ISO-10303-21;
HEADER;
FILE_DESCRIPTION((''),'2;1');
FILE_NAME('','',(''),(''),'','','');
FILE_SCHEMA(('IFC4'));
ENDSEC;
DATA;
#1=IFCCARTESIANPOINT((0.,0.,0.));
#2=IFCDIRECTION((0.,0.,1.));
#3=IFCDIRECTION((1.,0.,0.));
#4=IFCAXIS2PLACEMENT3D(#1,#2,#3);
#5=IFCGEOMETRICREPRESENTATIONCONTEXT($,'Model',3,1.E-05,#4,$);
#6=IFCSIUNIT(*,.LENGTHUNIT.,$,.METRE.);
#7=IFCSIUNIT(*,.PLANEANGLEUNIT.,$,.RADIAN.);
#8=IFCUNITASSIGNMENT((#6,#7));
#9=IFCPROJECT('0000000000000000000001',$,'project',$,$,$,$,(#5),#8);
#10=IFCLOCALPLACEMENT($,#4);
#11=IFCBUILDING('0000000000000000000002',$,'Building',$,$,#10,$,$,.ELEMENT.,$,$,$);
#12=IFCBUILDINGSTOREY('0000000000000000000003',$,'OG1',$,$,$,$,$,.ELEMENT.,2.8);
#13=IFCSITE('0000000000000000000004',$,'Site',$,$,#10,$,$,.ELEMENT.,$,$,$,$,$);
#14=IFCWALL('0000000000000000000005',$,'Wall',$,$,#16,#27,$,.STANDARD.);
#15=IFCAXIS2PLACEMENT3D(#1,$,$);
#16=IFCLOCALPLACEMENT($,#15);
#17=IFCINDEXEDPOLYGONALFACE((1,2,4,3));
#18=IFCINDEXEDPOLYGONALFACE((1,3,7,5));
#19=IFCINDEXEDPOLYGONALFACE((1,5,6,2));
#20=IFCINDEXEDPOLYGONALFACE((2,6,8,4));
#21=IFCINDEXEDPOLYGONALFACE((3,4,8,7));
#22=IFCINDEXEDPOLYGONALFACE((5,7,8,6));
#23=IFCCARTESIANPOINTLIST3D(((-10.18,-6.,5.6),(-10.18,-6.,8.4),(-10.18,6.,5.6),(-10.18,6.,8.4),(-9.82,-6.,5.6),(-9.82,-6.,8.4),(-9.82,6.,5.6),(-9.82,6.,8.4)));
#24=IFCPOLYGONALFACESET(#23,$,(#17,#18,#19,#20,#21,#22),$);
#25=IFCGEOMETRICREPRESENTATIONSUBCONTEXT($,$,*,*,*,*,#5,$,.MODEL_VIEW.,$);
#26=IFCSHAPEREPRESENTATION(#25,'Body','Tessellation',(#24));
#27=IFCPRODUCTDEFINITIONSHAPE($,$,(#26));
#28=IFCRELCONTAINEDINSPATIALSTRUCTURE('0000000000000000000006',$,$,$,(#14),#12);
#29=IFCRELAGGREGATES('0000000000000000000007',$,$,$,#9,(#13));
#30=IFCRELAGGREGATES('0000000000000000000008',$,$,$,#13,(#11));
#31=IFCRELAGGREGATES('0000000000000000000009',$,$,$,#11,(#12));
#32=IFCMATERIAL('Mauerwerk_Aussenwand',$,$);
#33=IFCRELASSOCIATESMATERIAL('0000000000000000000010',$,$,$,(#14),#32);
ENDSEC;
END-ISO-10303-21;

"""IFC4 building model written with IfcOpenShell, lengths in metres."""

from ifc_helpers import new_model, si_unit, frame, frame_2d, origin, origin_with_axes, place, context, subcontext, project, spatial, rectangle, extrude, material, element, save


model = new_model("IFC4")

# Units and contexts
model_context = context("Model", 3, precision=1e-05, world=origin_with_axes())
sub_context = subcontext(model_context, None, None, "MODEL_VIEW")
ifc_project = project(units=[si_unit("LENGTHUNIT", "METRE"), si_unit("PLANEANGLEUNIT", "RADIAN")], contexts=[model_context])

# Site, building, storey
placement_1 = place(None, origin_with_axes())
site = spatial("IfcSite", under=ifc_project, at=placement_1, Name="Site", CompositionType="ELEMENT")
building = spatial("IfcBuilding", under=site, at=placement_1, Name="Building", CompositionType="ELEMENT")
storey = spatial("IfcBuildingStorey", under=building, Name="OG1", CompositionType="ELEMENT", Elevation=2.8)

# Wall
ifc_material = material(Name="Mauerwerk_Aussenwand")
placement_2 = place(None, origin_with_axes())
placement_3 = place(placement_2, frame((0.0, 0.0, 2.8)))
wall_placement = place(placement_3, frame((-10.0, -6.0, 2.8), x_axis=(0.0, 1.0, 0.0)))
element("IfcWall", 1, at=wall_placement, inside=storey, material=ifc_material, Name="Wall", PredefinedType="STANDARD", context=sub_context, shape_type="SweptSolid", body=[
    extrude(rectangle(XDim=12.0, YDim=0.36, at=frame_2d((6.0, 0.0))), origin(), (0.0, 0.0, 1.0), 2.8),
])

save(model, "model.ifc")
